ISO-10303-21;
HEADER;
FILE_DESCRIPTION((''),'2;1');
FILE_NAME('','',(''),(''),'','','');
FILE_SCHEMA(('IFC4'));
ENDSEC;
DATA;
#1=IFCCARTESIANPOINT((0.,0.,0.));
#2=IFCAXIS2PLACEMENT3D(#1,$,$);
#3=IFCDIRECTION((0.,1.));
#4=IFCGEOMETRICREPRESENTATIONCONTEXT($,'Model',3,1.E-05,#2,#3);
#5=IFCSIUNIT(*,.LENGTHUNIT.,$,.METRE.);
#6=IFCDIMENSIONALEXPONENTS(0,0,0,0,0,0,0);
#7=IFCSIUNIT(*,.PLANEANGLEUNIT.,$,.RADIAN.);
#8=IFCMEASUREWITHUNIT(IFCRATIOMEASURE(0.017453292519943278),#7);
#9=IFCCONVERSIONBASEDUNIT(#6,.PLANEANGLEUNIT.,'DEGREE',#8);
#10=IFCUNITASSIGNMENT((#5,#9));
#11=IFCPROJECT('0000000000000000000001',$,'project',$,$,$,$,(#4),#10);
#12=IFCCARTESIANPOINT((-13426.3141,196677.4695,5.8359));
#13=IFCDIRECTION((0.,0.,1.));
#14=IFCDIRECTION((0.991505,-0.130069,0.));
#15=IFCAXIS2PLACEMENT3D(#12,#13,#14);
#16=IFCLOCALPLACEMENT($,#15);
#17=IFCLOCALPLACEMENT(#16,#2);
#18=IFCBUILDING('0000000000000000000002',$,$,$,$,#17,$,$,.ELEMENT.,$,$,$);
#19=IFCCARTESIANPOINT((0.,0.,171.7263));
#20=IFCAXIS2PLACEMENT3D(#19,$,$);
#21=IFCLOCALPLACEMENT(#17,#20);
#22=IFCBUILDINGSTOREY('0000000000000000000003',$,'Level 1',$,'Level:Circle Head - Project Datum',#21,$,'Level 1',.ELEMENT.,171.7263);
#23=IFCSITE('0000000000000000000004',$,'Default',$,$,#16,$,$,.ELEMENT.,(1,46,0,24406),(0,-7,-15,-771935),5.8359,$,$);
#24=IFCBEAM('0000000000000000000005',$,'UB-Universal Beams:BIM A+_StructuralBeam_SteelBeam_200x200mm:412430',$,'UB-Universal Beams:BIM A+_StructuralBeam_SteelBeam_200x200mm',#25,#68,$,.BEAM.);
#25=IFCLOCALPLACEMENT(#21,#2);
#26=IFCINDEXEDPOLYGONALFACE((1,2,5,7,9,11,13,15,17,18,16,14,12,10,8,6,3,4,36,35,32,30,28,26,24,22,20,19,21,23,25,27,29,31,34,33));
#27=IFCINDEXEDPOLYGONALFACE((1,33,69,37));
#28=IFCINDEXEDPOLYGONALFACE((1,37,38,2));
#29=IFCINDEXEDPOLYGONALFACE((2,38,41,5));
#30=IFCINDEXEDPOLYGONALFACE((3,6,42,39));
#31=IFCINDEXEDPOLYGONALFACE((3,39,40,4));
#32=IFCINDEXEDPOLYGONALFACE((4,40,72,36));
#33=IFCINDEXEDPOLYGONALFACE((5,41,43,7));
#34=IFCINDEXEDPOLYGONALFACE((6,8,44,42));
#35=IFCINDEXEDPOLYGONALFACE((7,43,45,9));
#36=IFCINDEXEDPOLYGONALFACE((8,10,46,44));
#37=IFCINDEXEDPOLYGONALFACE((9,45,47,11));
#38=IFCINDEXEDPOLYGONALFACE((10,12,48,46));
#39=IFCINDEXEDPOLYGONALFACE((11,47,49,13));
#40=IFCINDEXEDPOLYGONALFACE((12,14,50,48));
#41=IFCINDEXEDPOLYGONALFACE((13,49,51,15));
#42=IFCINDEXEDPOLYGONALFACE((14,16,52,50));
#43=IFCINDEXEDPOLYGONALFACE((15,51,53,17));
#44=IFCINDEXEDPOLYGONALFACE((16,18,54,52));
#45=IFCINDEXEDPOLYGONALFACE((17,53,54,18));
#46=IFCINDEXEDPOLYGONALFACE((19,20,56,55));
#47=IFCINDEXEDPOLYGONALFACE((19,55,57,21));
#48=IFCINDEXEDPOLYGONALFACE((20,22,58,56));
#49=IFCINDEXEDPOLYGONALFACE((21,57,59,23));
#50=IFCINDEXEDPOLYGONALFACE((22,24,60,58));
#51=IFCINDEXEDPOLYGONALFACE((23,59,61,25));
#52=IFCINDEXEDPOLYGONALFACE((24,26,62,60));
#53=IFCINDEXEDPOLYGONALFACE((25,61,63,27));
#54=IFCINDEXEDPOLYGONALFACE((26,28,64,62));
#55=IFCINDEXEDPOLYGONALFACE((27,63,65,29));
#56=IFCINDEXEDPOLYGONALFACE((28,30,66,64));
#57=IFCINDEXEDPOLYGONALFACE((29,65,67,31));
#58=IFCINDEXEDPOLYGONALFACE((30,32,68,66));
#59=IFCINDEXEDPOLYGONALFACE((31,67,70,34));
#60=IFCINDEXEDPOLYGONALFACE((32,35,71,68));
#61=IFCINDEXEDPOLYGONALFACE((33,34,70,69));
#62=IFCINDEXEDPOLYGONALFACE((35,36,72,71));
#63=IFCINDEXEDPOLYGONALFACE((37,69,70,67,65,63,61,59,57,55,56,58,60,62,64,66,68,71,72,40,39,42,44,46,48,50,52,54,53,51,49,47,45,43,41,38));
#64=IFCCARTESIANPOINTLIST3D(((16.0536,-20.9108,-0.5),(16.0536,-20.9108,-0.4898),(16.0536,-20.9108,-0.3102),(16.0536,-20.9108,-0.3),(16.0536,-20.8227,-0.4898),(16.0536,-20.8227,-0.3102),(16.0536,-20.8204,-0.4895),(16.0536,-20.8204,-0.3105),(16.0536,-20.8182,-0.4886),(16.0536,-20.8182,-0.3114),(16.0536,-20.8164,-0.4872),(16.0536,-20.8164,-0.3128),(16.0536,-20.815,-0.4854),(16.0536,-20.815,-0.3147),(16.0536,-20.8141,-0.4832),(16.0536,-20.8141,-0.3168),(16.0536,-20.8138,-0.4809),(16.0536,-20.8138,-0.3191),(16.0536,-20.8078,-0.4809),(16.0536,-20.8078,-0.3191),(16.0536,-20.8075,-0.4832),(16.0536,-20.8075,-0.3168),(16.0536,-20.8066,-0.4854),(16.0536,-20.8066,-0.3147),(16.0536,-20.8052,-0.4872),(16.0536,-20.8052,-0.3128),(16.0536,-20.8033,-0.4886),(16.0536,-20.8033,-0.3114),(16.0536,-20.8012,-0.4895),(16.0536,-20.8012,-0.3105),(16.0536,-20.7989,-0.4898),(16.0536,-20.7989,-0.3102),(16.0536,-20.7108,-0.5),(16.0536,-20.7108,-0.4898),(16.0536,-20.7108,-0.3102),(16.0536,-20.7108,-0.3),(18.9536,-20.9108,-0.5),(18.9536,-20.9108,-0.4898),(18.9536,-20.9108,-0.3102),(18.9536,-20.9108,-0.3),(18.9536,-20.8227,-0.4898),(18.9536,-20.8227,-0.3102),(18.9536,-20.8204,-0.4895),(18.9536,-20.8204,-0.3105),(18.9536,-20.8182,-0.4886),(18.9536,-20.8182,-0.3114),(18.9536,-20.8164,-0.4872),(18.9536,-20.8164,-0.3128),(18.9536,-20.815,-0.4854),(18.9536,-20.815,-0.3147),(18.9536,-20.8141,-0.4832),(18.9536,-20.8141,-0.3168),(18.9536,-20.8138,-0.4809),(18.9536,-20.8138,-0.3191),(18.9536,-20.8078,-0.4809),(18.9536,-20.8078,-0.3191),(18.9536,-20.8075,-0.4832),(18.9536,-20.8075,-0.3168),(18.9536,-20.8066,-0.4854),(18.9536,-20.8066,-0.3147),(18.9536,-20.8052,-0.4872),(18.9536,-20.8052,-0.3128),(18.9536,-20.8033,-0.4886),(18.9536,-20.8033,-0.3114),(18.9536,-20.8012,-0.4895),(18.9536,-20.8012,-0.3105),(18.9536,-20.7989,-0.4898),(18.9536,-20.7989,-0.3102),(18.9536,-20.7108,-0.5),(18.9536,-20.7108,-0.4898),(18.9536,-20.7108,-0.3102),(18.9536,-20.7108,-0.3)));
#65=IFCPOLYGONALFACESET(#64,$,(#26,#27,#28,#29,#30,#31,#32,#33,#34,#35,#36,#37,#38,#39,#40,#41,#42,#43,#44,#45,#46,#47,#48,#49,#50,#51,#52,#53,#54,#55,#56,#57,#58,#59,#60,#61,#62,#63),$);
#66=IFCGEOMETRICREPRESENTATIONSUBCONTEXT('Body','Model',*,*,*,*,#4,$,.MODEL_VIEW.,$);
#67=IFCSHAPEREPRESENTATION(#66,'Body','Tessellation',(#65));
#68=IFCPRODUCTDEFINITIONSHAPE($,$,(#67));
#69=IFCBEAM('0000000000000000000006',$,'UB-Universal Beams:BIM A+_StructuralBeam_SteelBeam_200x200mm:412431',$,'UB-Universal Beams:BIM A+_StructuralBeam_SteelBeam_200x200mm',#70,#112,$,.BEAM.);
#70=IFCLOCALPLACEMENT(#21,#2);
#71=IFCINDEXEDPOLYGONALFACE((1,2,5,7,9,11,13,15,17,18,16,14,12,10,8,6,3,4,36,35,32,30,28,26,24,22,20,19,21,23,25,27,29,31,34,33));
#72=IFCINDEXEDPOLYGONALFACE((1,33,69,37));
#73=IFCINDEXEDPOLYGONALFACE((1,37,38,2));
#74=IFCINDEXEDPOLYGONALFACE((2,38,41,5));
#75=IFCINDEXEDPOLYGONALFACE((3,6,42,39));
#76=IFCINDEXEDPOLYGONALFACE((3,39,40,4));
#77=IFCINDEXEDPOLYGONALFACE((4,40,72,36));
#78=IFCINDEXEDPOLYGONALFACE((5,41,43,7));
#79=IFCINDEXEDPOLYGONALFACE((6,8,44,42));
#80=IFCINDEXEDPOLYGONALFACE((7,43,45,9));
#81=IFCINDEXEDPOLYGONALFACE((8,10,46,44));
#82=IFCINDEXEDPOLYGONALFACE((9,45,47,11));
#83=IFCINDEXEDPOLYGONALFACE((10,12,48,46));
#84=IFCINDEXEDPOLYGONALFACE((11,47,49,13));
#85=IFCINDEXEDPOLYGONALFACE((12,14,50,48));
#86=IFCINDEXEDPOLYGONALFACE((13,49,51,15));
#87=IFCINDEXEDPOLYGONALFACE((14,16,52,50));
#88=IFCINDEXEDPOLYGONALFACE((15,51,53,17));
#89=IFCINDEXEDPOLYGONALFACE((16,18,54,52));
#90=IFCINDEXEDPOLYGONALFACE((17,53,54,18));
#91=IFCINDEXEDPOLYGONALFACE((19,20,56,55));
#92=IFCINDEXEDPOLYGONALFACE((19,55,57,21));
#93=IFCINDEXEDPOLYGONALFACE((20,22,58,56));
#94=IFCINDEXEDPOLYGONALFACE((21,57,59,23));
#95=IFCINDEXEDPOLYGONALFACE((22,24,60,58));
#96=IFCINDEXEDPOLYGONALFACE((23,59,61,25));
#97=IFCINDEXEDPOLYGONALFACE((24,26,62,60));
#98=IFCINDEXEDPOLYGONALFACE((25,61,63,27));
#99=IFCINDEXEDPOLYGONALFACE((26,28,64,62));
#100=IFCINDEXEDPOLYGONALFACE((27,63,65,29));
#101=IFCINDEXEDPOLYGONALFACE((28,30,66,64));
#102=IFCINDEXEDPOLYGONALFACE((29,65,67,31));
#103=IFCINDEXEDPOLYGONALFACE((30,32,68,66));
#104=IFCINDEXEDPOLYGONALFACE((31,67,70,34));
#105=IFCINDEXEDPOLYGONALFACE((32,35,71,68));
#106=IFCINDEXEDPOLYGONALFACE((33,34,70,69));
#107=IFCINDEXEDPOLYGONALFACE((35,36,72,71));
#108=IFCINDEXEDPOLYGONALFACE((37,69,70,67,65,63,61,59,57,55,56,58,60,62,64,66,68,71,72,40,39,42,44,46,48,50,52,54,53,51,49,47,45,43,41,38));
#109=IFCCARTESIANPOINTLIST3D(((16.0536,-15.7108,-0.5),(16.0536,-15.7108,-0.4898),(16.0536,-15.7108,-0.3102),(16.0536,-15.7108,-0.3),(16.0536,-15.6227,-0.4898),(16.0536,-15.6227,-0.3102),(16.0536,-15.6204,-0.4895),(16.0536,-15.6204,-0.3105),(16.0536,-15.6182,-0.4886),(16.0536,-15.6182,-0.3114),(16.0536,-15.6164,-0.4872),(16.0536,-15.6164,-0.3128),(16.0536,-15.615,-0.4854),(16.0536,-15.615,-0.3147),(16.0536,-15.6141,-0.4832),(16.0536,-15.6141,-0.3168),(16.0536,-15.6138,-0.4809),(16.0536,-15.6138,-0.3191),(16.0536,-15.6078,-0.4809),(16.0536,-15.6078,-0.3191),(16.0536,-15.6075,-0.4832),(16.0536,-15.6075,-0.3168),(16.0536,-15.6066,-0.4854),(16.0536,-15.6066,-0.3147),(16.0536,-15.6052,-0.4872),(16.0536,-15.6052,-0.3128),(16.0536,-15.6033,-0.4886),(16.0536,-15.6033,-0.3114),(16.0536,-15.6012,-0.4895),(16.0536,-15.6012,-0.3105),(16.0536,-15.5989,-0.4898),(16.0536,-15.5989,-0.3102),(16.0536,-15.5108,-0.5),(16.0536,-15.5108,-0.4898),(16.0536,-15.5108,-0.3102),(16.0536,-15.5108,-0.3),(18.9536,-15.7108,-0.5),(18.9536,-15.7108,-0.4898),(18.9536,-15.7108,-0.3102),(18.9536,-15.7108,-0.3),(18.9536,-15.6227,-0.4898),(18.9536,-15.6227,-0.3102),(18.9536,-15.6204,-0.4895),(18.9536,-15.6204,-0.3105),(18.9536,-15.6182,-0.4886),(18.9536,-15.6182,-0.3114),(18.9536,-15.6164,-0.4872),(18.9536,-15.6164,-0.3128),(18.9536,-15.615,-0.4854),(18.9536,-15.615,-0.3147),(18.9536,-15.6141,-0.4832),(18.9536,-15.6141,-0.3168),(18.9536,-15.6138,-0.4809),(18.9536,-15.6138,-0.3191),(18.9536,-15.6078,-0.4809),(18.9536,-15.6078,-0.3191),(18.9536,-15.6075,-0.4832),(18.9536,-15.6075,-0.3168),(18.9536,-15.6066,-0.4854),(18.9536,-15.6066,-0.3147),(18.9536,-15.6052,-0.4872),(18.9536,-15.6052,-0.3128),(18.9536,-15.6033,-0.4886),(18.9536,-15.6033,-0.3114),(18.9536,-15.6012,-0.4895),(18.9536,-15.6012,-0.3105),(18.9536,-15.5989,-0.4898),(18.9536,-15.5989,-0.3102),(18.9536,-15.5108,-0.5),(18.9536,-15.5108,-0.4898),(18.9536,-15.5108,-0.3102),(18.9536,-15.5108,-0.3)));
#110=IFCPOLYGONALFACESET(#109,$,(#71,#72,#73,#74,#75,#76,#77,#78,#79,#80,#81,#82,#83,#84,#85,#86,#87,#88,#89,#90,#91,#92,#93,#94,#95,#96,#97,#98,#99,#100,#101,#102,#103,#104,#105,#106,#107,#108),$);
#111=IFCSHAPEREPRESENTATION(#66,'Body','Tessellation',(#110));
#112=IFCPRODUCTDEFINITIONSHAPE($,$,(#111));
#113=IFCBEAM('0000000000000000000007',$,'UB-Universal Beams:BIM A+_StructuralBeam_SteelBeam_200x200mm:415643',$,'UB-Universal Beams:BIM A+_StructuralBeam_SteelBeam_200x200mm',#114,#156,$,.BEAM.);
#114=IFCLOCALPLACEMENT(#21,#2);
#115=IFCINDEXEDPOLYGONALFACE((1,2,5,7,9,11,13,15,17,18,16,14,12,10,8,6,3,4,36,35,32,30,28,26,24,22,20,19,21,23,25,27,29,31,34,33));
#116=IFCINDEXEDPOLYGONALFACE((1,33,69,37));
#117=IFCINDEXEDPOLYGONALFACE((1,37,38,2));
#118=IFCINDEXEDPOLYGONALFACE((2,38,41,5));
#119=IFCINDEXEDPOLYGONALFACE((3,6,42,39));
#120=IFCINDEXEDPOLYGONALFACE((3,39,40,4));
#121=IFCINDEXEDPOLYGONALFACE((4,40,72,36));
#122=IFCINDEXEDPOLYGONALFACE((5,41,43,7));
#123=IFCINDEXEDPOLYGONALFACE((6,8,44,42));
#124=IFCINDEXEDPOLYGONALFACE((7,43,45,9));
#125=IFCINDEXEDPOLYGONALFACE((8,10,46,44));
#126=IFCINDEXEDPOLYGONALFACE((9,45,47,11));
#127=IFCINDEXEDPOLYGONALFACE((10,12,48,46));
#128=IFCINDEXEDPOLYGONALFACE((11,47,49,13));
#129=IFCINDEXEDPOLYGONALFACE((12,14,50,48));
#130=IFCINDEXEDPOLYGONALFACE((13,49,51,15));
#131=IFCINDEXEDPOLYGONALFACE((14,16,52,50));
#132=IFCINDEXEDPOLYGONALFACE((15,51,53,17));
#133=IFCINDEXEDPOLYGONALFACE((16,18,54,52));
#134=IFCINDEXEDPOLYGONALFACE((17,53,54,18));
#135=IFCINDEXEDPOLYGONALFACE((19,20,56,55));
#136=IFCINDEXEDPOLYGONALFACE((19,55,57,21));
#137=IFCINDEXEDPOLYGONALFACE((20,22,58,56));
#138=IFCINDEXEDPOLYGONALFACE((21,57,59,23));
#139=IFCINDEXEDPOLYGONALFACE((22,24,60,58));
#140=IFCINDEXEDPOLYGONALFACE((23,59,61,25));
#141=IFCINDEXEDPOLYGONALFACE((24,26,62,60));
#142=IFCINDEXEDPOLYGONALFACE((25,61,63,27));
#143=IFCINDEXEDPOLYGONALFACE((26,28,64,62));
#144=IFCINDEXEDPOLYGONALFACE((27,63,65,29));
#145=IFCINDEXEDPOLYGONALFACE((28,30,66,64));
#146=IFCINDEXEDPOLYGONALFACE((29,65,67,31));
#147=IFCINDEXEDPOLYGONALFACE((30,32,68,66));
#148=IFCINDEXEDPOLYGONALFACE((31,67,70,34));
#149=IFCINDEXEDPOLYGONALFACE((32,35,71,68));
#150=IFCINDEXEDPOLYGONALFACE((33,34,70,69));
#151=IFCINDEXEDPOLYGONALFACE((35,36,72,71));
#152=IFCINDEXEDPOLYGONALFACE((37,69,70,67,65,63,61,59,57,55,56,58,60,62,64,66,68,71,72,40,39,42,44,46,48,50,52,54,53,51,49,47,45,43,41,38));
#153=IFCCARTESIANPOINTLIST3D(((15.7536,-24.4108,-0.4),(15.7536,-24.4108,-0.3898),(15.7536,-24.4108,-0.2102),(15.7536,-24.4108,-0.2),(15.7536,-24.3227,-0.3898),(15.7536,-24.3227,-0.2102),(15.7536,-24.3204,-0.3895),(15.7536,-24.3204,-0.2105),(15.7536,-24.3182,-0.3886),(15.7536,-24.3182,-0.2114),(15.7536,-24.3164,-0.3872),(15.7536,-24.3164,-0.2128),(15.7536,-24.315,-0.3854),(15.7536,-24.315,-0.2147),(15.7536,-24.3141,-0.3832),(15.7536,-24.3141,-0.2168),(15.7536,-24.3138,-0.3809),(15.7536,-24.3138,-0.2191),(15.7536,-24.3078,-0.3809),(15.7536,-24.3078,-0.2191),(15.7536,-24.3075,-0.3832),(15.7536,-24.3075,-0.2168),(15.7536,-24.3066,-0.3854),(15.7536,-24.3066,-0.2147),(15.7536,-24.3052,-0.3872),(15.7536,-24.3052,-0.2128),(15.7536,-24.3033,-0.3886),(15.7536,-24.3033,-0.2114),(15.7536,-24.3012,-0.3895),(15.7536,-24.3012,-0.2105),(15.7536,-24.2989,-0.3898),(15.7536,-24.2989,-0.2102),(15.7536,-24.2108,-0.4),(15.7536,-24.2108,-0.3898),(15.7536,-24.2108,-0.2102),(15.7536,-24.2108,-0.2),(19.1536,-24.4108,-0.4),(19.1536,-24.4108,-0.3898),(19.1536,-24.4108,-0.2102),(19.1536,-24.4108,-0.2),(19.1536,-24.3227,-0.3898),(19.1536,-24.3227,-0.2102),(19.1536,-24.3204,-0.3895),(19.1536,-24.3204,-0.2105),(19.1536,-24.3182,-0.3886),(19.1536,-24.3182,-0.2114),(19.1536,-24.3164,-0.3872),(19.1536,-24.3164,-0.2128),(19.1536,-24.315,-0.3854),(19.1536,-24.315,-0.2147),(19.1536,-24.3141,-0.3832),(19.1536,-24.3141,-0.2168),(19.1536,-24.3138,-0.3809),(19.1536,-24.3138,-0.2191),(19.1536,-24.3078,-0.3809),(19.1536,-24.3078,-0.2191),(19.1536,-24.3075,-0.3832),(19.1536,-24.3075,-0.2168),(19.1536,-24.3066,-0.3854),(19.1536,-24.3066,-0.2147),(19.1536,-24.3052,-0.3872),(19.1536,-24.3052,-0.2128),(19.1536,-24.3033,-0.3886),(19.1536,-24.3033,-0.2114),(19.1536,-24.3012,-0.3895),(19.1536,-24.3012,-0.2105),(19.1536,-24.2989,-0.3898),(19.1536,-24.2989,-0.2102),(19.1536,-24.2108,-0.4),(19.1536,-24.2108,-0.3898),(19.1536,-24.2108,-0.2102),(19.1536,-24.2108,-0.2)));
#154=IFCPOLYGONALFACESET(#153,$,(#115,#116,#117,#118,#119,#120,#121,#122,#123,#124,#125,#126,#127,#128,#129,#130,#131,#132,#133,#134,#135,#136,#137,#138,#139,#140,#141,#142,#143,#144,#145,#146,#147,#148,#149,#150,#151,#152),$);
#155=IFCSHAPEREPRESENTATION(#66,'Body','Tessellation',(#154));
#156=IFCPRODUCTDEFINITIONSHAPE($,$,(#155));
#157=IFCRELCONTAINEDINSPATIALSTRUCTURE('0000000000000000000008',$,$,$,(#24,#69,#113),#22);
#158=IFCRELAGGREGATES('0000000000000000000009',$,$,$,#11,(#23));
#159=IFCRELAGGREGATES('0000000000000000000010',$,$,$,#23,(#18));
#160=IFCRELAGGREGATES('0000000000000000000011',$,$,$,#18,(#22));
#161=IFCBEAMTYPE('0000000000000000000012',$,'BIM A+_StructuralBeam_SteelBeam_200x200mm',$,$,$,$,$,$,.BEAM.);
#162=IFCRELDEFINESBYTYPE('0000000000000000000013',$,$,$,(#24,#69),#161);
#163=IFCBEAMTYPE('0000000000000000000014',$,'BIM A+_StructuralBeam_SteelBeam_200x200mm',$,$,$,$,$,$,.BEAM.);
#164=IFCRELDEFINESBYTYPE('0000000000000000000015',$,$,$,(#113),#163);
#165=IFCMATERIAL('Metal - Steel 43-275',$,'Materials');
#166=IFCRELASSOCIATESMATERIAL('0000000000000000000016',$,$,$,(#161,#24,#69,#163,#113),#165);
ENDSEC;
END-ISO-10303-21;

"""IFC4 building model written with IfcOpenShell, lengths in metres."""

from ifc_helpers import new_model, entity, si_unit, converted_unit, direction, frame, origin, place, context, subcontext, project, spatial, line, arc, indexed_curve, outline, extrude, source, transform, mapped, material, type_object, type_shapes, element, save


model = new_model("IFC4")

# Units and contexts
model_context = context("Model", 3, precision=1e-05, world=origin(), true_north=direction((0.0, 1.0)))
body_context = subcontext(model_context, "Body", "Model", "MODEL_VIEW")
ifc_project = project(units=[si_unit("LENGTHUNIT", "METRE"), converted_unit("PLANEANGLEUNIT", "DEGREE", entity("IfcRatioMeasure", 0.017453292519943278), si_unit("PLANEANGLEUNIT", "RADIAN"), dimensions=[0, 0, 0, 0, 0, 0, 0])], contexts=[model_context])

# Site, building, storey
site_placement = place(None, frame((-13426.3141, 196677.4695, 5.8359), z_axis=(0.0, 0.0, 1.0), x_axis=(0.991505, -0.130069, 0.0)))
site = spatial("IfcSite", under=ifc_project, at=site_placement, Name="Default", CompositionType="ELEMENT", RefLatitude=(1, 46, 0, 24406), RefLongitude=(0, -7, -15, -771935), RefElevation=5.8359)
building_placement = place(site_placement, origin())
building = spatial("IfcBuilding", under=site, at=building_placement, CompositionType="ELEMENT")
storey_placement = place(building_placement, frame((0.0, 0.0, 171.7263)))
storey = spatial("IfcBuildingStorey", under=building, at=storey_placement, Name="Level 1", ObjectType="Level:Circle Head - Project Datum", LongName="Level 1", CompositionType="ELEMENT", Elevation=171.7263)

# Shared definitions
ifc_material_1 = material(Name="Metal - Steel 43-275", Category="Materials")

# Beams
beam_type_1 = type_object("IfcBeamType", Name="BIM A+_StructuralBeam_SteelBeam_200x200mm", PredefinedType="BEAM", material=ifc_material_1)
shared_shape_1 = source(origin(), body_context, "Body", "SweptSolid", [
    extrude(outline(indexed_curve([(-0.1, -0.1), (-0.0898, -0.1), (-0.0898, -0.0119), (-0.0872, -0.0056), (-0.0809, -0.003), (0.0809, -0.003), (0.0872, -0.0056), (0.0898, -0.0119), (0.0898, -0.1), (0.1, -0.1), (0.1, 0.1), (0.0898, 0.1), (0.0898, 0.0119), (0.0872, 0.0056), (0.0809, 0.003), (-0.0809, 0.003), (-0.0872, 0.0056), (-0.0898, 0.0119), (-0.0898, 0.1), (-0.1, 0.1)], segments=[line(1, 2, 3), arc(3, 4, 5), line(5, 6), arc(6, 7, 8), line(8, 9, 10, 11, 12, 13), arc(13, 14, 15), line(15, 16), arc(16, 17, 18), line(18, 19, 20, 1)], self_intersect=False)), frame((-0.1639, 0.0, 0.0), z_axis=(1.0, 0.0, 0.0), x_axis=(0.0, 0.0, -1.0)), (0.0, 0.0, 1.0), 2.9),
])
type_shapes(beam_type_1, [shared_shape_1])
for number, where, z_axis, x_axis, name in (
    (1, (18.7897, -20.8108, -0.4), (0.0, 0.0, 1.0), (-1.0, 0.0, 0.0), "UB-Universal Beams:BIM A+_StructuralBeam_SteelBeam_200x200mm:412430"),
    (2, (18.7897, -15.6108, -0.4), (0.0, 0.0, 1.0), (-1.0, 0.0, 0.0), "UB-Universal Beams:BIM A+_StructuralBeam_SteelBeam_200x200mm:412431"),
):
    element("IfcBeam", number, at=place(storey_placement, frame(where, z_axis=z_axis, x_axis=x_axis)), inside=storey, type_object=beam_type_1, material=ifc_material_1, Name=name, ObjectType="UB-Universal Beams:BIM A+_StructuralBeam_SteelBeam_200x200mm", PredefinedType="BEAM", context=body_context, shape_type="MappedRepresentation", body=[
        mapped(shared_shape_1, transform((0.0, 0.0, 0.0), scale=1.0)),
    ])
beam_type_2 = type_object("IfcBeamType", Name="BIM A+_StructuralBeam_SteelBeam_200x200mm", PredefinedType="BEAM", material=ifc_material_1)
shared_shape_2 = source(origin(), body_context, "Body", "SweptSolid", [
    extrude(outline(indexed_curve([(-0.1, -0.1), (-0.0898, -0.1), (-0.0898, -0.0119), (-0.0872, -0.0056), (-0.0809, -0.003), (0.0809, -0.003), (0.0872, -0.0056), (0.0898, -0.0119), (0.0898, -0.1), (0.1, -0.1), (0.1, 0.1), (0.0898, 0.1), (0.0898, 0.0119), (0.0872, 0.0056), (0.0809, 0.003), (-0.0809, 0.003), (-0.0872, 0.0056), (-0.0898, 0.0119), (-0.0898, 0.1), (-0.1, 0.1)], segments=[line(1, 2, 3), arc(3, 4, 5), line(5, 6), arc(6, 7, 8), line(8, 9, 10, 11, 12, 13), arc(13, 14, 15), line(15, 16), arc(16, 17, 18), line(18, 19, 20, 1)], self_intersect=False)), frame((-0.3639, 0.0, 0.0), z_axis=(1.0, 0.0, 0.0), x_axis=(0.0, 0.0, -1.0)), (0.0, 0.0, 1.0), 3.4),
])
type_shapes(beam_type_2, [shared_shape_2])
beam_1_placement = place(storey_placement, frame((18.7897, -24.3108, -0.3), z_axis=(0.0, 0.0, 1.0), x_axis=(-1.0, 0.0, 0.0)))
element("IfcBeam", 3, at=beam_1_placement, inside=storey, type_object=beam_type_2, material=ifc_material_1, Name="UB-Universal Beams:BIM A+_StructuralBeam_SteelBeam_200x200mm:415643", ObjectType="UB-Universal Beams:BIM A+_StructuralBeam_SteelBeam_200x200mm", PredefinedType="BEAM", context=body_context, shape_type="MappedRepresentation", body=[
    mapped(shared_shape_2, transform((0.0, 0.0, 0.0), scale=1.0)),
])

save(model, "model.ifc")
